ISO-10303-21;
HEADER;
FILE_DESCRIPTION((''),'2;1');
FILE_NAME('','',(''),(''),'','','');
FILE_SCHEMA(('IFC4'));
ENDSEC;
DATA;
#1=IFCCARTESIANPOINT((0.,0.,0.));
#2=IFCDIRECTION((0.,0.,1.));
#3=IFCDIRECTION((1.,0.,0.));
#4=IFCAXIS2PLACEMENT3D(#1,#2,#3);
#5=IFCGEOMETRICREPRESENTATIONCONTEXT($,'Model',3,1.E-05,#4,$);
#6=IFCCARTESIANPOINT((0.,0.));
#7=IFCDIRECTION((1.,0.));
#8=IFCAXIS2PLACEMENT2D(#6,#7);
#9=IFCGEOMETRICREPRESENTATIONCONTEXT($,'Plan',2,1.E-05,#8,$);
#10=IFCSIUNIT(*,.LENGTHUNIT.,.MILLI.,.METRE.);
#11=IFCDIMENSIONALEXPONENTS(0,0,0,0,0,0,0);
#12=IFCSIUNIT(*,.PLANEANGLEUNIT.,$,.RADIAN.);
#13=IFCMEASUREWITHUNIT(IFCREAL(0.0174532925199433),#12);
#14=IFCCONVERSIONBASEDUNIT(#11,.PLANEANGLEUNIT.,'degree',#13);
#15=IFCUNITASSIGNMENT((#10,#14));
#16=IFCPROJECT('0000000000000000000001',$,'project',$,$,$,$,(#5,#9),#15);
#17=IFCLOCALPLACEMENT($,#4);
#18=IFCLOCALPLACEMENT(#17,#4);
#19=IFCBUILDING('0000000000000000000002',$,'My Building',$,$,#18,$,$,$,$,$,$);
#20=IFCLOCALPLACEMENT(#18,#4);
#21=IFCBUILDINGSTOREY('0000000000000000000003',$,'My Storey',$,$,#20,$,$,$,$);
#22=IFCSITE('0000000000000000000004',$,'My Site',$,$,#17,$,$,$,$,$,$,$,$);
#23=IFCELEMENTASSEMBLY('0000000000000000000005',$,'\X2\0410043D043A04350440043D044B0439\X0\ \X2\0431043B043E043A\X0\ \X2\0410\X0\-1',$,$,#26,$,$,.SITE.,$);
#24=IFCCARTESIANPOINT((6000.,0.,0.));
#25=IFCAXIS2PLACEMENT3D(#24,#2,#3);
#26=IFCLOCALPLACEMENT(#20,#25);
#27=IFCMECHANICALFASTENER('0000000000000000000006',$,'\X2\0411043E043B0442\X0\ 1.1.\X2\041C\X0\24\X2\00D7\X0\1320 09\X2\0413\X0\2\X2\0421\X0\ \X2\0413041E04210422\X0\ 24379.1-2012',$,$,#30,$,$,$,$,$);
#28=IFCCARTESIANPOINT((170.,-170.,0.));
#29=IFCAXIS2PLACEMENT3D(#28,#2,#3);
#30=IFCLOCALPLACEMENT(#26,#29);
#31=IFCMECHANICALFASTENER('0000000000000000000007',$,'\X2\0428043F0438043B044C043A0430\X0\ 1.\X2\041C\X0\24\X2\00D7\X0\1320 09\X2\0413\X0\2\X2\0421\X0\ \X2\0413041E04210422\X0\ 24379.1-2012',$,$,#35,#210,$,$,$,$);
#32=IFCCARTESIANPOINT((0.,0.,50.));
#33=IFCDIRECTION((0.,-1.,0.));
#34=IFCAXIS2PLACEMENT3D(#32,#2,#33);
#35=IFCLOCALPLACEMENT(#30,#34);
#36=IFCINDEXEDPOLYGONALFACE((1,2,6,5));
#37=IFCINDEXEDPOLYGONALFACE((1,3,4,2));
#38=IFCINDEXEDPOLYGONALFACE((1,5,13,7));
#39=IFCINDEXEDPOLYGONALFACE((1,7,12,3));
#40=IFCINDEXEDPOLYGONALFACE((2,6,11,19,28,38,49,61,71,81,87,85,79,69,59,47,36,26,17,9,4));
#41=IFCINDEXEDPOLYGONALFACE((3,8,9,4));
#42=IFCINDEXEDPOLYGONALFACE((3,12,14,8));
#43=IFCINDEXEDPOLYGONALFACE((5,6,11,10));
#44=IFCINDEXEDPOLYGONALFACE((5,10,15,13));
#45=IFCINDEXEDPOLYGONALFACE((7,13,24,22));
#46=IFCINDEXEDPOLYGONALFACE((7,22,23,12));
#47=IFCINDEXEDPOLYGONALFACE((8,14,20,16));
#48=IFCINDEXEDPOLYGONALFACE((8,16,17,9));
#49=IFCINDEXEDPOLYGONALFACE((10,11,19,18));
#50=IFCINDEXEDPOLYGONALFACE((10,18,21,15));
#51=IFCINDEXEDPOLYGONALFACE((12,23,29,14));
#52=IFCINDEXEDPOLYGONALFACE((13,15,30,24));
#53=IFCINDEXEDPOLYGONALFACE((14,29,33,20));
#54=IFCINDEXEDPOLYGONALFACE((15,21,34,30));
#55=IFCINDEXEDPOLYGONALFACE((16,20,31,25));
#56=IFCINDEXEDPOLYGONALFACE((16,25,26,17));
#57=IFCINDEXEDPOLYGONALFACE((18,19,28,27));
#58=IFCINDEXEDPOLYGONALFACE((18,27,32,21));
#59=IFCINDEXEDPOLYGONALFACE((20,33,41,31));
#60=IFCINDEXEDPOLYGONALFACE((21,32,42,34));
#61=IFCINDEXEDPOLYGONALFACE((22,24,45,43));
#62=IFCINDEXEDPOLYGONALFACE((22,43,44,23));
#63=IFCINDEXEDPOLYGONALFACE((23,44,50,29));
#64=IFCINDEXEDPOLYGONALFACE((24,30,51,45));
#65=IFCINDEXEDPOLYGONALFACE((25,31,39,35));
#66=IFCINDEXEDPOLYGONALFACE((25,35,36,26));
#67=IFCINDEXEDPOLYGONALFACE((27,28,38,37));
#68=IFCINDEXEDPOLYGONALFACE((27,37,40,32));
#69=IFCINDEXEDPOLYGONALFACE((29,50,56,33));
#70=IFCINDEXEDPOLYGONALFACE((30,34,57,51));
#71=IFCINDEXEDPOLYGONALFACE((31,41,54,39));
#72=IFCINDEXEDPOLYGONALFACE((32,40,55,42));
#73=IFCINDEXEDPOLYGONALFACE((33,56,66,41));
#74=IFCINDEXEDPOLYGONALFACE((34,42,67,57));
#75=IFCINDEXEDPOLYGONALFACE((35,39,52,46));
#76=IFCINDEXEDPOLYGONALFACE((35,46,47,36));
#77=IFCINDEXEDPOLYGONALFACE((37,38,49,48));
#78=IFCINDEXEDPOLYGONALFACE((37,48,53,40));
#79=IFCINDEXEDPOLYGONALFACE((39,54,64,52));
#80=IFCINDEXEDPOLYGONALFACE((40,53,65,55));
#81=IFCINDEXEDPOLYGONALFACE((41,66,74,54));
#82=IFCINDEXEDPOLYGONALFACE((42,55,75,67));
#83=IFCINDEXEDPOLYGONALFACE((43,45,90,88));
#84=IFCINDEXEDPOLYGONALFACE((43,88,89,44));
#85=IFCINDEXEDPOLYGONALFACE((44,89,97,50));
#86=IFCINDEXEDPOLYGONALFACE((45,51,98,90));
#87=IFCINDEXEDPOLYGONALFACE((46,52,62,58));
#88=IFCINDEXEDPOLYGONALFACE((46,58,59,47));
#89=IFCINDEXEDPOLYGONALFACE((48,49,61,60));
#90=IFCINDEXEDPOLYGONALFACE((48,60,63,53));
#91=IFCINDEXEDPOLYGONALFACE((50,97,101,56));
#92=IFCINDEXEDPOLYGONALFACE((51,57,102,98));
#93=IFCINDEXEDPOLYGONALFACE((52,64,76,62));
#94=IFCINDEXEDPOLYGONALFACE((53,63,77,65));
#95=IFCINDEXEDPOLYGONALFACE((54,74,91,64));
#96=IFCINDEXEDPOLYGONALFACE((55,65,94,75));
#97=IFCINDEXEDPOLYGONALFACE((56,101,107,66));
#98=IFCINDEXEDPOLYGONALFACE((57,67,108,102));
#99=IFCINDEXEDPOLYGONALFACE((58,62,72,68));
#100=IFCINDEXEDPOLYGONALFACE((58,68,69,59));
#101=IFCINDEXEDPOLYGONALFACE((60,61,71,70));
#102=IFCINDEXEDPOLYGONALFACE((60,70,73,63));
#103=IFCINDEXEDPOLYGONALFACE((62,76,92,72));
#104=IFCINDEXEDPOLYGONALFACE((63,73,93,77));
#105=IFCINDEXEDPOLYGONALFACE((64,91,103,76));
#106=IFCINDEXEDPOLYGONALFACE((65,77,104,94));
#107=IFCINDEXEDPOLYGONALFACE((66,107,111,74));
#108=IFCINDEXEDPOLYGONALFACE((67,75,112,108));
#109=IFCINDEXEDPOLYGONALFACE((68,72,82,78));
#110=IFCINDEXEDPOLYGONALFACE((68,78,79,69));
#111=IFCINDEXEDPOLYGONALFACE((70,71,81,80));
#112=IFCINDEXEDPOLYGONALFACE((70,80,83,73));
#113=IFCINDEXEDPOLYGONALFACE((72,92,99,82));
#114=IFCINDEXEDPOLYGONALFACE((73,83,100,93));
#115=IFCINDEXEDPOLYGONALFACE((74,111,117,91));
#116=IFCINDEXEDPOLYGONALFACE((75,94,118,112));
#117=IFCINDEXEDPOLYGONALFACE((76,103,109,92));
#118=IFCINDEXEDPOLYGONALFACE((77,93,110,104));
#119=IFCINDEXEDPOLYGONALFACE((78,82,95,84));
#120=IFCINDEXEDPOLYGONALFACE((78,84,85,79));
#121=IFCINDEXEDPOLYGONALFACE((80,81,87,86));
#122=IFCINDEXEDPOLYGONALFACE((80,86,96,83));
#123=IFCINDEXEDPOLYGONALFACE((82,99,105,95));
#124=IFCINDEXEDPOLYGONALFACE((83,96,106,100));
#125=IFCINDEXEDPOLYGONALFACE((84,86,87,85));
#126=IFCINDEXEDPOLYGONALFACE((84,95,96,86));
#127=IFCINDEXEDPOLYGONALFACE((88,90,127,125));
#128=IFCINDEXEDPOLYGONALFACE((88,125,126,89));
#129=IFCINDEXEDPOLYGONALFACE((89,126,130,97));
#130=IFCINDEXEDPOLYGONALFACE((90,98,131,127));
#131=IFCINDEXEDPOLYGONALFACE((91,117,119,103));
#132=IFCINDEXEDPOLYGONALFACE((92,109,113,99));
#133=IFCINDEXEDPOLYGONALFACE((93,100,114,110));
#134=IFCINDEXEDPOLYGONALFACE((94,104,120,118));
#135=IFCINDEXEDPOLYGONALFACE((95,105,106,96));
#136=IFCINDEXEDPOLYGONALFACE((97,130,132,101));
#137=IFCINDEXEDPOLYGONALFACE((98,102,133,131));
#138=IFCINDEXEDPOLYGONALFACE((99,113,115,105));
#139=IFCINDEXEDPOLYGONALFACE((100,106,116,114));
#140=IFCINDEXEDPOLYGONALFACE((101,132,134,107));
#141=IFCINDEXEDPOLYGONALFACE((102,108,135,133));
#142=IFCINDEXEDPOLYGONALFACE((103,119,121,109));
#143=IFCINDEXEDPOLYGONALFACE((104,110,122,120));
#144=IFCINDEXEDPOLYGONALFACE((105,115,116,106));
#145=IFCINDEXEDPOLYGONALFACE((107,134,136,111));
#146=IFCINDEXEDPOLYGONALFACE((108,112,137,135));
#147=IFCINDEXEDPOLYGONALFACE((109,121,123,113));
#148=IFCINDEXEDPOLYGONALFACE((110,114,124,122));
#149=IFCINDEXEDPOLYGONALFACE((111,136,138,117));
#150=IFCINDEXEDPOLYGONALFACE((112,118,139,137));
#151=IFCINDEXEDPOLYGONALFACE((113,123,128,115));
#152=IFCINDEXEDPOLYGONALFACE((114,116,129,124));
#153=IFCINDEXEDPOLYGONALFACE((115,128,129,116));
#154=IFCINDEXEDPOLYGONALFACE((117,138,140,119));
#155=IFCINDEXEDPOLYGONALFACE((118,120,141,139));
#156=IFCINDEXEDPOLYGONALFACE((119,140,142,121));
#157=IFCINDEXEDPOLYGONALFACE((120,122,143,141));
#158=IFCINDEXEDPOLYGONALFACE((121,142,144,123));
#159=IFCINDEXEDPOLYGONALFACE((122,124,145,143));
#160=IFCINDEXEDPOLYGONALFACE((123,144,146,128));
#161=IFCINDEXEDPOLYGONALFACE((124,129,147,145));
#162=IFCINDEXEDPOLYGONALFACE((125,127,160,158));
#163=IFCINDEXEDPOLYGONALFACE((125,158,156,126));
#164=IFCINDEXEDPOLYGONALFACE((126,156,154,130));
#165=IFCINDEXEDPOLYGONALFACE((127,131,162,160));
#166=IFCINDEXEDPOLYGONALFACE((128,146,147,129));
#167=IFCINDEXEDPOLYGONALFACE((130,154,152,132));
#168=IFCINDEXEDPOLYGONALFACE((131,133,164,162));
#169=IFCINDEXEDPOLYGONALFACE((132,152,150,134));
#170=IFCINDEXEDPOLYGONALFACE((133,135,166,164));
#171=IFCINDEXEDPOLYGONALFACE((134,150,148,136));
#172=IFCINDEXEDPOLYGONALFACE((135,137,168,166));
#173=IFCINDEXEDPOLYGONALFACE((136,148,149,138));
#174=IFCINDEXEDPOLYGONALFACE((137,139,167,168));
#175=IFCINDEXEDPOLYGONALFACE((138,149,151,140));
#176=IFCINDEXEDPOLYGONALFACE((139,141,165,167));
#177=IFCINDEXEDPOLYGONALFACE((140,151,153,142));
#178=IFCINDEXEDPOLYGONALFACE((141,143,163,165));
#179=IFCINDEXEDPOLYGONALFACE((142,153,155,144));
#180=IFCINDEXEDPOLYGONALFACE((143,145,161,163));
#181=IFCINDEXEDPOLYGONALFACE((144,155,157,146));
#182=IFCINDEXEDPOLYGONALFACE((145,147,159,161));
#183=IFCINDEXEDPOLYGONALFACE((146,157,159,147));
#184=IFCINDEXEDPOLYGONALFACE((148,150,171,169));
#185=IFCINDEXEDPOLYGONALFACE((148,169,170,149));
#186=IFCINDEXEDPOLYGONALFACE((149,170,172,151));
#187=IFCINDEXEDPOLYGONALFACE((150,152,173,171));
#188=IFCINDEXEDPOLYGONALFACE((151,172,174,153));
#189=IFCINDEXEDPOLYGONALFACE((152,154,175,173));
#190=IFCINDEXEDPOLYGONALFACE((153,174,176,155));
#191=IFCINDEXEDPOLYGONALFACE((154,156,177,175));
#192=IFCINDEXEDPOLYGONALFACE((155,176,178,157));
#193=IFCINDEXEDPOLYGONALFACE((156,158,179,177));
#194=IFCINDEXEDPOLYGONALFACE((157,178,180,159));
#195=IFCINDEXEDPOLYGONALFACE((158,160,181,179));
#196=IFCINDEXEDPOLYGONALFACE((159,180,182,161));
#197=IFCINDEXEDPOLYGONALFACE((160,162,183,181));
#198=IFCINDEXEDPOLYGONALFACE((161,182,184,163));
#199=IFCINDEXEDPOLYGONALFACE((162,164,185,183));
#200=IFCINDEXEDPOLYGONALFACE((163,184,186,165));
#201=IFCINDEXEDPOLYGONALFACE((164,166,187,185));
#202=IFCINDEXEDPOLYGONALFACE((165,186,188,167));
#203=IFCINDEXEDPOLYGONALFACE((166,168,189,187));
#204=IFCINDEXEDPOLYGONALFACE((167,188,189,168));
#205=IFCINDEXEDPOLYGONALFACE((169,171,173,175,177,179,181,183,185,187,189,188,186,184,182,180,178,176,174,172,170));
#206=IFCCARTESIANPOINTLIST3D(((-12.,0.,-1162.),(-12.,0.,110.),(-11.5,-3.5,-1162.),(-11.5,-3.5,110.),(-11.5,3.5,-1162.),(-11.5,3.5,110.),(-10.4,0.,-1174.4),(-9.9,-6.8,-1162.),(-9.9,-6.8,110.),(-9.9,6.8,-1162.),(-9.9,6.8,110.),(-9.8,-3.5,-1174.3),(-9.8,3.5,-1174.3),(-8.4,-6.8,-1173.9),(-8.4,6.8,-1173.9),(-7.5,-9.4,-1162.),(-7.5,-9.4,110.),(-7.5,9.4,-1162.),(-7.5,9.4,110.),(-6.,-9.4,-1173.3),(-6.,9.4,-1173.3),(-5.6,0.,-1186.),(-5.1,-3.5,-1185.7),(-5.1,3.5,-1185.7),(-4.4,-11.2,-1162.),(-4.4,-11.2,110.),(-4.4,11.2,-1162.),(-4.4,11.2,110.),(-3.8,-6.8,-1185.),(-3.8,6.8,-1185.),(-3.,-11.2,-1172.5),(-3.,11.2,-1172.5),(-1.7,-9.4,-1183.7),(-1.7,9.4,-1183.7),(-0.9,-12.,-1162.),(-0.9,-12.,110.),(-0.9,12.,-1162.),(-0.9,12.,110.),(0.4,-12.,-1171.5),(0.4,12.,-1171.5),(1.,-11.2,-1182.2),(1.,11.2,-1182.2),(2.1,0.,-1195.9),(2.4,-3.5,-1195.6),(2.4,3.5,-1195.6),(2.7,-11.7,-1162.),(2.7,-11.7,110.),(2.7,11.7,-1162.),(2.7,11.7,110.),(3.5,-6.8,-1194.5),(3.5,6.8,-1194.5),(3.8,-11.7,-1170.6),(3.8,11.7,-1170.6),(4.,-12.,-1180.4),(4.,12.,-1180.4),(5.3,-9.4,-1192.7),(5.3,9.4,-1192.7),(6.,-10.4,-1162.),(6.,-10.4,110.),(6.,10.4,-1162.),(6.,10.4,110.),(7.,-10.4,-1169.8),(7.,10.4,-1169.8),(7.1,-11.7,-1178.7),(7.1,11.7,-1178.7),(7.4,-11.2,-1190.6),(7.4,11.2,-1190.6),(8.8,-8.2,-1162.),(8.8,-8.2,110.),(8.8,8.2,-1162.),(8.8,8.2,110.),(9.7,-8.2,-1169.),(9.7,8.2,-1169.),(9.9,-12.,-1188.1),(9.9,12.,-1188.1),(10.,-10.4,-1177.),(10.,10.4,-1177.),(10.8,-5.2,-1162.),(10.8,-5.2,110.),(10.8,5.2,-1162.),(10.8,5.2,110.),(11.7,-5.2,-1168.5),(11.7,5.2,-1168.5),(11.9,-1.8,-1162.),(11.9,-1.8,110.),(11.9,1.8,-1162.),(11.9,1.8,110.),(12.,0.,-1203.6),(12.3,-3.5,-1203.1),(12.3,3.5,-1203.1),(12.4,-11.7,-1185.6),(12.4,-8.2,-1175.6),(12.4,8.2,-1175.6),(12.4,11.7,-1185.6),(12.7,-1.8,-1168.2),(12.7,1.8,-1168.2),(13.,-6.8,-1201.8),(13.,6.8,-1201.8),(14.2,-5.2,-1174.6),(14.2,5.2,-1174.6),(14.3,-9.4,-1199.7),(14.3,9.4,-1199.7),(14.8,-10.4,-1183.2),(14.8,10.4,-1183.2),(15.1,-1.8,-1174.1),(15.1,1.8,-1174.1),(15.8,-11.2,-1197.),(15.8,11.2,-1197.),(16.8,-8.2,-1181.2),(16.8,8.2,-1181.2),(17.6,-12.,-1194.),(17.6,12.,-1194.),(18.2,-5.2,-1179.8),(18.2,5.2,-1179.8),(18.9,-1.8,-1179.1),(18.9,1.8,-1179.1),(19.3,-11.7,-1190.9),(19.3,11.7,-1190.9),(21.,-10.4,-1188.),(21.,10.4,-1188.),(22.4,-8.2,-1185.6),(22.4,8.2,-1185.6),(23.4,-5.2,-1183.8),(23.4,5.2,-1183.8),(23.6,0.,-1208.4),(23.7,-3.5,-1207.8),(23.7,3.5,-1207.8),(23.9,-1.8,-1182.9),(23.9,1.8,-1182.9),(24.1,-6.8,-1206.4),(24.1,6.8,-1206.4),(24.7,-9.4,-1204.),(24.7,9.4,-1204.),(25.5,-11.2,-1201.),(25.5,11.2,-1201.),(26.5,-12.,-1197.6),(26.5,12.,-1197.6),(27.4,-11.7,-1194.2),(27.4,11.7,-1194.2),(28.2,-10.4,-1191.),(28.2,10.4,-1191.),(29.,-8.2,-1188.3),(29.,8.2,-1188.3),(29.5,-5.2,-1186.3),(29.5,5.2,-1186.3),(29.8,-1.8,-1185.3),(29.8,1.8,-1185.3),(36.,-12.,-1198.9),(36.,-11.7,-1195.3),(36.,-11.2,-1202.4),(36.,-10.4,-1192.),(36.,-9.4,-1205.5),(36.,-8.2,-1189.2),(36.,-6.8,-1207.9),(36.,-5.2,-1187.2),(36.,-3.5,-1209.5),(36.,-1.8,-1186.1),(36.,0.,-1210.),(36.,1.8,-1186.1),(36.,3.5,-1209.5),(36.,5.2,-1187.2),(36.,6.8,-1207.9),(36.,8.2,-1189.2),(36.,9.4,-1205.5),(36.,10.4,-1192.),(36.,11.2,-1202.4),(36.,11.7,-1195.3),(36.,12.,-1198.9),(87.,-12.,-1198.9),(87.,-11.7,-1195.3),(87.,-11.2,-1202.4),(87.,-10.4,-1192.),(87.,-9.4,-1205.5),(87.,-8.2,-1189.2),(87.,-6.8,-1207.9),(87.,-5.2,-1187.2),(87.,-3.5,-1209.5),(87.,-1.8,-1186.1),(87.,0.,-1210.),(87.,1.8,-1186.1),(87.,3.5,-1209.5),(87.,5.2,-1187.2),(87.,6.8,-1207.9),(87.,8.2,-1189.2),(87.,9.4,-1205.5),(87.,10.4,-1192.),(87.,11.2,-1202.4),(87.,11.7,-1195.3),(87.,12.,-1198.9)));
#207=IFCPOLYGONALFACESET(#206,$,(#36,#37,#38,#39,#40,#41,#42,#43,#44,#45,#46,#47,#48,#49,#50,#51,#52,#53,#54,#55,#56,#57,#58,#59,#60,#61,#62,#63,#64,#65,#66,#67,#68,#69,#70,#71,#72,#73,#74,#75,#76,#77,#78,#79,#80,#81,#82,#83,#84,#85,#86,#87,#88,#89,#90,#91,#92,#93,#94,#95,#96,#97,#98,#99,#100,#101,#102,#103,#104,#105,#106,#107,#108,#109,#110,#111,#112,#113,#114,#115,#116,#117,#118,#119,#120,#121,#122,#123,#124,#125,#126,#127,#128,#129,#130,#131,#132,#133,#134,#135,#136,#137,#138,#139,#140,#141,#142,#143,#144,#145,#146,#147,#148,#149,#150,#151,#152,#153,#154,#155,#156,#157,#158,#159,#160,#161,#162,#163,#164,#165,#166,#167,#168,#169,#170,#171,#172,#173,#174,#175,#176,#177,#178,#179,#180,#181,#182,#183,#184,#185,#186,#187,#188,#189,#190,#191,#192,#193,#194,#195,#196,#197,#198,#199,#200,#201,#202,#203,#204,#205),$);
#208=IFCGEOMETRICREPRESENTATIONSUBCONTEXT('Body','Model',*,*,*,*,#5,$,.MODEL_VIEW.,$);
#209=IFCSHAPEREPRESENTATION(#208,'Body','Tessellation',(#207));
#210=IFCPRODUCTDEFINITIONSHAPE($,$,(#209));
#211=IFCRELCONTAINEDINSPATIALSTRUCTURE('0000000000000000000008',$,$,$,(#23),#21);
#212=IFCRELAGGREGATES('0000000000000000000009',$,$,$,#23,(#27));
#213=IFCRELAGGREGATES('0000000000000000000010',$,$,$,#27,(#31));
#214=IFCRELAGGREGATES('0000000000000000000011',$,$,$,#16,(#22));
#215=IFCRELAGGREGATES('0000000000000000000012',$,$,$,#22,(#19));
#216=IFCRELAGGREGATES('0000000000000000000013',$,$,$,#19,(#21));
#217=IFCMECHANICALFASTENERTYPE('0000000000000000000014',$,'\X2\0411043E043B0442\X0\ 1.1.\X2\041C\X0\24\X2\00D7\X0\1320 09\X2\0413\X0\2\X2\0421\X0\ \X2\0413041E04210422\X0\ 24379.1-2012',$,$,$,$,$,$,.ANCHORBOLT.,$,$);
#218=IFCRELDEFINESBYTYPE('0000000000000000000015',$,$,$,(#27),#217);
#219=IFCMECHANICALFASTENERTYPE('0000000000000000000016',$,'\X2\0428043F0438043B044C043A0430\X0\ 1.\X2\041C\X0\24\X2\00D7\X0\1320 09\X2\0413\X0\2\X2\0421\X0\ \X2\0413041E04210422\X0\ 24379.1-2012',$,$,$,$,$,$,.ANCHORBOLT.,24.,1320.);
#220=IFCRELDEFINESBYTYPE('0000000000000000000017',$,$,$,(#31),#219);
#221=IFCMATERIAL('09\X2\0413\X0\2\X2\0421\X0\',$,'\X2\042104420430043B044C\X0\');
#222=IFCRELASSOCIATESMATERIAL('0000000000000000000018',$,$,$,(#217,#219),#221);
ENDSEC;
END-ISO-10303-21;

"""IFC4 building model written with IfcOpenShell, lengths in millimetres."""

from ifc_helpers import new_model, entity, si_unit, converted_unit, frame, origin_with_axes, origin_2d_with_axis, place, context, subcontext, project, spatial, source, transform, mapped, material, type_object, type_shapes, element, aggregate, save


model = new_model("IFC4")

# Units and contexts
model_context = context("Model", 3, precision=1e-05, world=origin_with_axes())
plan_context = context("Plan", 2, precision=1e-05, world=origin_2d_with_axis())
body_context = subcontext(model_context, "Body", "Model", "MODEL_VIEW")
ifc_project = project(units=[si_unit("LENGTHUNIT", "METRE", prefix="MILLI"), converted_unit("PLANEANGLEUNIT", "degree", entity("IfcReal", 0.0174532925199433), si_unit("PLANEANGLEUNIT", "RADIAN"), dimensions=[0, 0, 0, 0, 0, 0, 0])], contexts=[model_context, plan_context])

# Site, building, storey
site_placement = place(None, origin_with_axes())
site = spatial("IfcSite", under=ifc_project, at=site_placement, Name="My Site")
building_placement = place(site_placement, origin_with_axes())
building = spatial("IfcBuilding", under=site, at=building_placement, Name="My Building")
storey_placement = place(building_placement, origin_with_axes())
storey = spatial("IfcBuildingStorey", under=building, at=storey_placement, Name="My Storey")

# Element assembly, mechanical fasteners
assembly_1_placement = place(storey_placement, frame((6000.0, 0.0, 0.0), z_axis=(0.0, 0.0, 1.0), x_axis=(1.0, 0.0, 0.0)))
assembly_1 = element("IfcElementAssembly", 1, at=assembly_1_placement, inside=storey, Name="Анкерный блок А-1", AssemblyPlace="SITE")
ifc_material_1 = material(Name="09Г2С", Category="Сталь")
mechanical_fastener_type_1 = type_object("IfcMechanicalFastenerType", Name="Болт 1.1.М24×1320 09Г2С ГОСТ 24379.1-2012", PredefinedType="ANCHORBOLT", material=ifc_material_1)
mechanical_fastener_type_2 = type_object("IfcMechanicalFastenerType", Name="Шпилька 1.М24×1320 09Г2С ГОСТ 24379.1-2012", NominalDiameter=24.0, NominalLength=1320.0, PredefinedType="ANCHORBOLT", material=ifc_material_1)
shared_shape_1 = source(frame((0.0, 0.0, 110.0), z_axis=(0.0, 0.0, 1.0), x_axis=(1.0, 0.0, 0.0)), body_context, "Body", "AdvancedSweptSolid", [
    entity("IfcSweptDiskSolid", entity("IfcIndexedPolyCurve", entity("IfcCartesianPointList3D", [[0.0, 0.0, 0.0], [0.0, 0.0, -1272.0], [10.5, 0.0, -1297.5], [36.0, 0.0, -1308.0], [87.0, 0.0, -1308.0]]), [entity("IfcLineIndex", [1, 2]), entity("IfcArcIndex", [2, 3, 4]), entity("IfcLineIndex", [4, 5])]), 12.0),
])
type_shapes(mechanical_fastener_type_2, [shared_shape_1])
mechanical_fastener_1_placement = place(assembly_1_placement, frame((170.0, -170.0, 0.0), z_axis=(0.0, 0.0, 1.0), x_axis=(1.0, 0.0, 0.0)))
mechanical_fastener_1 = element("IfcMechanicalFastener", 2, at=mechanical_fastener_1_placement, type_object=mechanical_fastener_type_1, Name="Болт 1.1.М24×1320 09Г2С ГОСТ 24379.1-2012")
aggregate(assembly_1, [mechanical_fastener_1])
mechanical_fastener_2_placement = place(mechanical_fastener_1_placement, frame((0.0, 0.0, 50.0), z_axis=(0.0, 0.0, 1.0), x_axis=(0.0, -1.0, 0.0)))
mechanical_fastener_2 = element("IfcMechanicalFastener", 3, at=mechanical_fastener_2_placement, type_object=mechanical_fastener_type_2, Name="Шпилька 1.М24×1320 09Г2С ГОСТ 24379.1-2012", context=body_context, shape_type="MappedRepresentation", body=[
    mapped(shared_shape_1, transform((0.0, 0.0, 0.0), x_axis=(1.0, 0.0, 0.0), y_axis=(0.0, 1.0, 0.0), z_axis=(0.0, 0.0, 1.0), scale=1.0)),
])
aggregate(mechanical_fastener_1, [mechanical_fastener_2])

save(model, "model.ifc")
